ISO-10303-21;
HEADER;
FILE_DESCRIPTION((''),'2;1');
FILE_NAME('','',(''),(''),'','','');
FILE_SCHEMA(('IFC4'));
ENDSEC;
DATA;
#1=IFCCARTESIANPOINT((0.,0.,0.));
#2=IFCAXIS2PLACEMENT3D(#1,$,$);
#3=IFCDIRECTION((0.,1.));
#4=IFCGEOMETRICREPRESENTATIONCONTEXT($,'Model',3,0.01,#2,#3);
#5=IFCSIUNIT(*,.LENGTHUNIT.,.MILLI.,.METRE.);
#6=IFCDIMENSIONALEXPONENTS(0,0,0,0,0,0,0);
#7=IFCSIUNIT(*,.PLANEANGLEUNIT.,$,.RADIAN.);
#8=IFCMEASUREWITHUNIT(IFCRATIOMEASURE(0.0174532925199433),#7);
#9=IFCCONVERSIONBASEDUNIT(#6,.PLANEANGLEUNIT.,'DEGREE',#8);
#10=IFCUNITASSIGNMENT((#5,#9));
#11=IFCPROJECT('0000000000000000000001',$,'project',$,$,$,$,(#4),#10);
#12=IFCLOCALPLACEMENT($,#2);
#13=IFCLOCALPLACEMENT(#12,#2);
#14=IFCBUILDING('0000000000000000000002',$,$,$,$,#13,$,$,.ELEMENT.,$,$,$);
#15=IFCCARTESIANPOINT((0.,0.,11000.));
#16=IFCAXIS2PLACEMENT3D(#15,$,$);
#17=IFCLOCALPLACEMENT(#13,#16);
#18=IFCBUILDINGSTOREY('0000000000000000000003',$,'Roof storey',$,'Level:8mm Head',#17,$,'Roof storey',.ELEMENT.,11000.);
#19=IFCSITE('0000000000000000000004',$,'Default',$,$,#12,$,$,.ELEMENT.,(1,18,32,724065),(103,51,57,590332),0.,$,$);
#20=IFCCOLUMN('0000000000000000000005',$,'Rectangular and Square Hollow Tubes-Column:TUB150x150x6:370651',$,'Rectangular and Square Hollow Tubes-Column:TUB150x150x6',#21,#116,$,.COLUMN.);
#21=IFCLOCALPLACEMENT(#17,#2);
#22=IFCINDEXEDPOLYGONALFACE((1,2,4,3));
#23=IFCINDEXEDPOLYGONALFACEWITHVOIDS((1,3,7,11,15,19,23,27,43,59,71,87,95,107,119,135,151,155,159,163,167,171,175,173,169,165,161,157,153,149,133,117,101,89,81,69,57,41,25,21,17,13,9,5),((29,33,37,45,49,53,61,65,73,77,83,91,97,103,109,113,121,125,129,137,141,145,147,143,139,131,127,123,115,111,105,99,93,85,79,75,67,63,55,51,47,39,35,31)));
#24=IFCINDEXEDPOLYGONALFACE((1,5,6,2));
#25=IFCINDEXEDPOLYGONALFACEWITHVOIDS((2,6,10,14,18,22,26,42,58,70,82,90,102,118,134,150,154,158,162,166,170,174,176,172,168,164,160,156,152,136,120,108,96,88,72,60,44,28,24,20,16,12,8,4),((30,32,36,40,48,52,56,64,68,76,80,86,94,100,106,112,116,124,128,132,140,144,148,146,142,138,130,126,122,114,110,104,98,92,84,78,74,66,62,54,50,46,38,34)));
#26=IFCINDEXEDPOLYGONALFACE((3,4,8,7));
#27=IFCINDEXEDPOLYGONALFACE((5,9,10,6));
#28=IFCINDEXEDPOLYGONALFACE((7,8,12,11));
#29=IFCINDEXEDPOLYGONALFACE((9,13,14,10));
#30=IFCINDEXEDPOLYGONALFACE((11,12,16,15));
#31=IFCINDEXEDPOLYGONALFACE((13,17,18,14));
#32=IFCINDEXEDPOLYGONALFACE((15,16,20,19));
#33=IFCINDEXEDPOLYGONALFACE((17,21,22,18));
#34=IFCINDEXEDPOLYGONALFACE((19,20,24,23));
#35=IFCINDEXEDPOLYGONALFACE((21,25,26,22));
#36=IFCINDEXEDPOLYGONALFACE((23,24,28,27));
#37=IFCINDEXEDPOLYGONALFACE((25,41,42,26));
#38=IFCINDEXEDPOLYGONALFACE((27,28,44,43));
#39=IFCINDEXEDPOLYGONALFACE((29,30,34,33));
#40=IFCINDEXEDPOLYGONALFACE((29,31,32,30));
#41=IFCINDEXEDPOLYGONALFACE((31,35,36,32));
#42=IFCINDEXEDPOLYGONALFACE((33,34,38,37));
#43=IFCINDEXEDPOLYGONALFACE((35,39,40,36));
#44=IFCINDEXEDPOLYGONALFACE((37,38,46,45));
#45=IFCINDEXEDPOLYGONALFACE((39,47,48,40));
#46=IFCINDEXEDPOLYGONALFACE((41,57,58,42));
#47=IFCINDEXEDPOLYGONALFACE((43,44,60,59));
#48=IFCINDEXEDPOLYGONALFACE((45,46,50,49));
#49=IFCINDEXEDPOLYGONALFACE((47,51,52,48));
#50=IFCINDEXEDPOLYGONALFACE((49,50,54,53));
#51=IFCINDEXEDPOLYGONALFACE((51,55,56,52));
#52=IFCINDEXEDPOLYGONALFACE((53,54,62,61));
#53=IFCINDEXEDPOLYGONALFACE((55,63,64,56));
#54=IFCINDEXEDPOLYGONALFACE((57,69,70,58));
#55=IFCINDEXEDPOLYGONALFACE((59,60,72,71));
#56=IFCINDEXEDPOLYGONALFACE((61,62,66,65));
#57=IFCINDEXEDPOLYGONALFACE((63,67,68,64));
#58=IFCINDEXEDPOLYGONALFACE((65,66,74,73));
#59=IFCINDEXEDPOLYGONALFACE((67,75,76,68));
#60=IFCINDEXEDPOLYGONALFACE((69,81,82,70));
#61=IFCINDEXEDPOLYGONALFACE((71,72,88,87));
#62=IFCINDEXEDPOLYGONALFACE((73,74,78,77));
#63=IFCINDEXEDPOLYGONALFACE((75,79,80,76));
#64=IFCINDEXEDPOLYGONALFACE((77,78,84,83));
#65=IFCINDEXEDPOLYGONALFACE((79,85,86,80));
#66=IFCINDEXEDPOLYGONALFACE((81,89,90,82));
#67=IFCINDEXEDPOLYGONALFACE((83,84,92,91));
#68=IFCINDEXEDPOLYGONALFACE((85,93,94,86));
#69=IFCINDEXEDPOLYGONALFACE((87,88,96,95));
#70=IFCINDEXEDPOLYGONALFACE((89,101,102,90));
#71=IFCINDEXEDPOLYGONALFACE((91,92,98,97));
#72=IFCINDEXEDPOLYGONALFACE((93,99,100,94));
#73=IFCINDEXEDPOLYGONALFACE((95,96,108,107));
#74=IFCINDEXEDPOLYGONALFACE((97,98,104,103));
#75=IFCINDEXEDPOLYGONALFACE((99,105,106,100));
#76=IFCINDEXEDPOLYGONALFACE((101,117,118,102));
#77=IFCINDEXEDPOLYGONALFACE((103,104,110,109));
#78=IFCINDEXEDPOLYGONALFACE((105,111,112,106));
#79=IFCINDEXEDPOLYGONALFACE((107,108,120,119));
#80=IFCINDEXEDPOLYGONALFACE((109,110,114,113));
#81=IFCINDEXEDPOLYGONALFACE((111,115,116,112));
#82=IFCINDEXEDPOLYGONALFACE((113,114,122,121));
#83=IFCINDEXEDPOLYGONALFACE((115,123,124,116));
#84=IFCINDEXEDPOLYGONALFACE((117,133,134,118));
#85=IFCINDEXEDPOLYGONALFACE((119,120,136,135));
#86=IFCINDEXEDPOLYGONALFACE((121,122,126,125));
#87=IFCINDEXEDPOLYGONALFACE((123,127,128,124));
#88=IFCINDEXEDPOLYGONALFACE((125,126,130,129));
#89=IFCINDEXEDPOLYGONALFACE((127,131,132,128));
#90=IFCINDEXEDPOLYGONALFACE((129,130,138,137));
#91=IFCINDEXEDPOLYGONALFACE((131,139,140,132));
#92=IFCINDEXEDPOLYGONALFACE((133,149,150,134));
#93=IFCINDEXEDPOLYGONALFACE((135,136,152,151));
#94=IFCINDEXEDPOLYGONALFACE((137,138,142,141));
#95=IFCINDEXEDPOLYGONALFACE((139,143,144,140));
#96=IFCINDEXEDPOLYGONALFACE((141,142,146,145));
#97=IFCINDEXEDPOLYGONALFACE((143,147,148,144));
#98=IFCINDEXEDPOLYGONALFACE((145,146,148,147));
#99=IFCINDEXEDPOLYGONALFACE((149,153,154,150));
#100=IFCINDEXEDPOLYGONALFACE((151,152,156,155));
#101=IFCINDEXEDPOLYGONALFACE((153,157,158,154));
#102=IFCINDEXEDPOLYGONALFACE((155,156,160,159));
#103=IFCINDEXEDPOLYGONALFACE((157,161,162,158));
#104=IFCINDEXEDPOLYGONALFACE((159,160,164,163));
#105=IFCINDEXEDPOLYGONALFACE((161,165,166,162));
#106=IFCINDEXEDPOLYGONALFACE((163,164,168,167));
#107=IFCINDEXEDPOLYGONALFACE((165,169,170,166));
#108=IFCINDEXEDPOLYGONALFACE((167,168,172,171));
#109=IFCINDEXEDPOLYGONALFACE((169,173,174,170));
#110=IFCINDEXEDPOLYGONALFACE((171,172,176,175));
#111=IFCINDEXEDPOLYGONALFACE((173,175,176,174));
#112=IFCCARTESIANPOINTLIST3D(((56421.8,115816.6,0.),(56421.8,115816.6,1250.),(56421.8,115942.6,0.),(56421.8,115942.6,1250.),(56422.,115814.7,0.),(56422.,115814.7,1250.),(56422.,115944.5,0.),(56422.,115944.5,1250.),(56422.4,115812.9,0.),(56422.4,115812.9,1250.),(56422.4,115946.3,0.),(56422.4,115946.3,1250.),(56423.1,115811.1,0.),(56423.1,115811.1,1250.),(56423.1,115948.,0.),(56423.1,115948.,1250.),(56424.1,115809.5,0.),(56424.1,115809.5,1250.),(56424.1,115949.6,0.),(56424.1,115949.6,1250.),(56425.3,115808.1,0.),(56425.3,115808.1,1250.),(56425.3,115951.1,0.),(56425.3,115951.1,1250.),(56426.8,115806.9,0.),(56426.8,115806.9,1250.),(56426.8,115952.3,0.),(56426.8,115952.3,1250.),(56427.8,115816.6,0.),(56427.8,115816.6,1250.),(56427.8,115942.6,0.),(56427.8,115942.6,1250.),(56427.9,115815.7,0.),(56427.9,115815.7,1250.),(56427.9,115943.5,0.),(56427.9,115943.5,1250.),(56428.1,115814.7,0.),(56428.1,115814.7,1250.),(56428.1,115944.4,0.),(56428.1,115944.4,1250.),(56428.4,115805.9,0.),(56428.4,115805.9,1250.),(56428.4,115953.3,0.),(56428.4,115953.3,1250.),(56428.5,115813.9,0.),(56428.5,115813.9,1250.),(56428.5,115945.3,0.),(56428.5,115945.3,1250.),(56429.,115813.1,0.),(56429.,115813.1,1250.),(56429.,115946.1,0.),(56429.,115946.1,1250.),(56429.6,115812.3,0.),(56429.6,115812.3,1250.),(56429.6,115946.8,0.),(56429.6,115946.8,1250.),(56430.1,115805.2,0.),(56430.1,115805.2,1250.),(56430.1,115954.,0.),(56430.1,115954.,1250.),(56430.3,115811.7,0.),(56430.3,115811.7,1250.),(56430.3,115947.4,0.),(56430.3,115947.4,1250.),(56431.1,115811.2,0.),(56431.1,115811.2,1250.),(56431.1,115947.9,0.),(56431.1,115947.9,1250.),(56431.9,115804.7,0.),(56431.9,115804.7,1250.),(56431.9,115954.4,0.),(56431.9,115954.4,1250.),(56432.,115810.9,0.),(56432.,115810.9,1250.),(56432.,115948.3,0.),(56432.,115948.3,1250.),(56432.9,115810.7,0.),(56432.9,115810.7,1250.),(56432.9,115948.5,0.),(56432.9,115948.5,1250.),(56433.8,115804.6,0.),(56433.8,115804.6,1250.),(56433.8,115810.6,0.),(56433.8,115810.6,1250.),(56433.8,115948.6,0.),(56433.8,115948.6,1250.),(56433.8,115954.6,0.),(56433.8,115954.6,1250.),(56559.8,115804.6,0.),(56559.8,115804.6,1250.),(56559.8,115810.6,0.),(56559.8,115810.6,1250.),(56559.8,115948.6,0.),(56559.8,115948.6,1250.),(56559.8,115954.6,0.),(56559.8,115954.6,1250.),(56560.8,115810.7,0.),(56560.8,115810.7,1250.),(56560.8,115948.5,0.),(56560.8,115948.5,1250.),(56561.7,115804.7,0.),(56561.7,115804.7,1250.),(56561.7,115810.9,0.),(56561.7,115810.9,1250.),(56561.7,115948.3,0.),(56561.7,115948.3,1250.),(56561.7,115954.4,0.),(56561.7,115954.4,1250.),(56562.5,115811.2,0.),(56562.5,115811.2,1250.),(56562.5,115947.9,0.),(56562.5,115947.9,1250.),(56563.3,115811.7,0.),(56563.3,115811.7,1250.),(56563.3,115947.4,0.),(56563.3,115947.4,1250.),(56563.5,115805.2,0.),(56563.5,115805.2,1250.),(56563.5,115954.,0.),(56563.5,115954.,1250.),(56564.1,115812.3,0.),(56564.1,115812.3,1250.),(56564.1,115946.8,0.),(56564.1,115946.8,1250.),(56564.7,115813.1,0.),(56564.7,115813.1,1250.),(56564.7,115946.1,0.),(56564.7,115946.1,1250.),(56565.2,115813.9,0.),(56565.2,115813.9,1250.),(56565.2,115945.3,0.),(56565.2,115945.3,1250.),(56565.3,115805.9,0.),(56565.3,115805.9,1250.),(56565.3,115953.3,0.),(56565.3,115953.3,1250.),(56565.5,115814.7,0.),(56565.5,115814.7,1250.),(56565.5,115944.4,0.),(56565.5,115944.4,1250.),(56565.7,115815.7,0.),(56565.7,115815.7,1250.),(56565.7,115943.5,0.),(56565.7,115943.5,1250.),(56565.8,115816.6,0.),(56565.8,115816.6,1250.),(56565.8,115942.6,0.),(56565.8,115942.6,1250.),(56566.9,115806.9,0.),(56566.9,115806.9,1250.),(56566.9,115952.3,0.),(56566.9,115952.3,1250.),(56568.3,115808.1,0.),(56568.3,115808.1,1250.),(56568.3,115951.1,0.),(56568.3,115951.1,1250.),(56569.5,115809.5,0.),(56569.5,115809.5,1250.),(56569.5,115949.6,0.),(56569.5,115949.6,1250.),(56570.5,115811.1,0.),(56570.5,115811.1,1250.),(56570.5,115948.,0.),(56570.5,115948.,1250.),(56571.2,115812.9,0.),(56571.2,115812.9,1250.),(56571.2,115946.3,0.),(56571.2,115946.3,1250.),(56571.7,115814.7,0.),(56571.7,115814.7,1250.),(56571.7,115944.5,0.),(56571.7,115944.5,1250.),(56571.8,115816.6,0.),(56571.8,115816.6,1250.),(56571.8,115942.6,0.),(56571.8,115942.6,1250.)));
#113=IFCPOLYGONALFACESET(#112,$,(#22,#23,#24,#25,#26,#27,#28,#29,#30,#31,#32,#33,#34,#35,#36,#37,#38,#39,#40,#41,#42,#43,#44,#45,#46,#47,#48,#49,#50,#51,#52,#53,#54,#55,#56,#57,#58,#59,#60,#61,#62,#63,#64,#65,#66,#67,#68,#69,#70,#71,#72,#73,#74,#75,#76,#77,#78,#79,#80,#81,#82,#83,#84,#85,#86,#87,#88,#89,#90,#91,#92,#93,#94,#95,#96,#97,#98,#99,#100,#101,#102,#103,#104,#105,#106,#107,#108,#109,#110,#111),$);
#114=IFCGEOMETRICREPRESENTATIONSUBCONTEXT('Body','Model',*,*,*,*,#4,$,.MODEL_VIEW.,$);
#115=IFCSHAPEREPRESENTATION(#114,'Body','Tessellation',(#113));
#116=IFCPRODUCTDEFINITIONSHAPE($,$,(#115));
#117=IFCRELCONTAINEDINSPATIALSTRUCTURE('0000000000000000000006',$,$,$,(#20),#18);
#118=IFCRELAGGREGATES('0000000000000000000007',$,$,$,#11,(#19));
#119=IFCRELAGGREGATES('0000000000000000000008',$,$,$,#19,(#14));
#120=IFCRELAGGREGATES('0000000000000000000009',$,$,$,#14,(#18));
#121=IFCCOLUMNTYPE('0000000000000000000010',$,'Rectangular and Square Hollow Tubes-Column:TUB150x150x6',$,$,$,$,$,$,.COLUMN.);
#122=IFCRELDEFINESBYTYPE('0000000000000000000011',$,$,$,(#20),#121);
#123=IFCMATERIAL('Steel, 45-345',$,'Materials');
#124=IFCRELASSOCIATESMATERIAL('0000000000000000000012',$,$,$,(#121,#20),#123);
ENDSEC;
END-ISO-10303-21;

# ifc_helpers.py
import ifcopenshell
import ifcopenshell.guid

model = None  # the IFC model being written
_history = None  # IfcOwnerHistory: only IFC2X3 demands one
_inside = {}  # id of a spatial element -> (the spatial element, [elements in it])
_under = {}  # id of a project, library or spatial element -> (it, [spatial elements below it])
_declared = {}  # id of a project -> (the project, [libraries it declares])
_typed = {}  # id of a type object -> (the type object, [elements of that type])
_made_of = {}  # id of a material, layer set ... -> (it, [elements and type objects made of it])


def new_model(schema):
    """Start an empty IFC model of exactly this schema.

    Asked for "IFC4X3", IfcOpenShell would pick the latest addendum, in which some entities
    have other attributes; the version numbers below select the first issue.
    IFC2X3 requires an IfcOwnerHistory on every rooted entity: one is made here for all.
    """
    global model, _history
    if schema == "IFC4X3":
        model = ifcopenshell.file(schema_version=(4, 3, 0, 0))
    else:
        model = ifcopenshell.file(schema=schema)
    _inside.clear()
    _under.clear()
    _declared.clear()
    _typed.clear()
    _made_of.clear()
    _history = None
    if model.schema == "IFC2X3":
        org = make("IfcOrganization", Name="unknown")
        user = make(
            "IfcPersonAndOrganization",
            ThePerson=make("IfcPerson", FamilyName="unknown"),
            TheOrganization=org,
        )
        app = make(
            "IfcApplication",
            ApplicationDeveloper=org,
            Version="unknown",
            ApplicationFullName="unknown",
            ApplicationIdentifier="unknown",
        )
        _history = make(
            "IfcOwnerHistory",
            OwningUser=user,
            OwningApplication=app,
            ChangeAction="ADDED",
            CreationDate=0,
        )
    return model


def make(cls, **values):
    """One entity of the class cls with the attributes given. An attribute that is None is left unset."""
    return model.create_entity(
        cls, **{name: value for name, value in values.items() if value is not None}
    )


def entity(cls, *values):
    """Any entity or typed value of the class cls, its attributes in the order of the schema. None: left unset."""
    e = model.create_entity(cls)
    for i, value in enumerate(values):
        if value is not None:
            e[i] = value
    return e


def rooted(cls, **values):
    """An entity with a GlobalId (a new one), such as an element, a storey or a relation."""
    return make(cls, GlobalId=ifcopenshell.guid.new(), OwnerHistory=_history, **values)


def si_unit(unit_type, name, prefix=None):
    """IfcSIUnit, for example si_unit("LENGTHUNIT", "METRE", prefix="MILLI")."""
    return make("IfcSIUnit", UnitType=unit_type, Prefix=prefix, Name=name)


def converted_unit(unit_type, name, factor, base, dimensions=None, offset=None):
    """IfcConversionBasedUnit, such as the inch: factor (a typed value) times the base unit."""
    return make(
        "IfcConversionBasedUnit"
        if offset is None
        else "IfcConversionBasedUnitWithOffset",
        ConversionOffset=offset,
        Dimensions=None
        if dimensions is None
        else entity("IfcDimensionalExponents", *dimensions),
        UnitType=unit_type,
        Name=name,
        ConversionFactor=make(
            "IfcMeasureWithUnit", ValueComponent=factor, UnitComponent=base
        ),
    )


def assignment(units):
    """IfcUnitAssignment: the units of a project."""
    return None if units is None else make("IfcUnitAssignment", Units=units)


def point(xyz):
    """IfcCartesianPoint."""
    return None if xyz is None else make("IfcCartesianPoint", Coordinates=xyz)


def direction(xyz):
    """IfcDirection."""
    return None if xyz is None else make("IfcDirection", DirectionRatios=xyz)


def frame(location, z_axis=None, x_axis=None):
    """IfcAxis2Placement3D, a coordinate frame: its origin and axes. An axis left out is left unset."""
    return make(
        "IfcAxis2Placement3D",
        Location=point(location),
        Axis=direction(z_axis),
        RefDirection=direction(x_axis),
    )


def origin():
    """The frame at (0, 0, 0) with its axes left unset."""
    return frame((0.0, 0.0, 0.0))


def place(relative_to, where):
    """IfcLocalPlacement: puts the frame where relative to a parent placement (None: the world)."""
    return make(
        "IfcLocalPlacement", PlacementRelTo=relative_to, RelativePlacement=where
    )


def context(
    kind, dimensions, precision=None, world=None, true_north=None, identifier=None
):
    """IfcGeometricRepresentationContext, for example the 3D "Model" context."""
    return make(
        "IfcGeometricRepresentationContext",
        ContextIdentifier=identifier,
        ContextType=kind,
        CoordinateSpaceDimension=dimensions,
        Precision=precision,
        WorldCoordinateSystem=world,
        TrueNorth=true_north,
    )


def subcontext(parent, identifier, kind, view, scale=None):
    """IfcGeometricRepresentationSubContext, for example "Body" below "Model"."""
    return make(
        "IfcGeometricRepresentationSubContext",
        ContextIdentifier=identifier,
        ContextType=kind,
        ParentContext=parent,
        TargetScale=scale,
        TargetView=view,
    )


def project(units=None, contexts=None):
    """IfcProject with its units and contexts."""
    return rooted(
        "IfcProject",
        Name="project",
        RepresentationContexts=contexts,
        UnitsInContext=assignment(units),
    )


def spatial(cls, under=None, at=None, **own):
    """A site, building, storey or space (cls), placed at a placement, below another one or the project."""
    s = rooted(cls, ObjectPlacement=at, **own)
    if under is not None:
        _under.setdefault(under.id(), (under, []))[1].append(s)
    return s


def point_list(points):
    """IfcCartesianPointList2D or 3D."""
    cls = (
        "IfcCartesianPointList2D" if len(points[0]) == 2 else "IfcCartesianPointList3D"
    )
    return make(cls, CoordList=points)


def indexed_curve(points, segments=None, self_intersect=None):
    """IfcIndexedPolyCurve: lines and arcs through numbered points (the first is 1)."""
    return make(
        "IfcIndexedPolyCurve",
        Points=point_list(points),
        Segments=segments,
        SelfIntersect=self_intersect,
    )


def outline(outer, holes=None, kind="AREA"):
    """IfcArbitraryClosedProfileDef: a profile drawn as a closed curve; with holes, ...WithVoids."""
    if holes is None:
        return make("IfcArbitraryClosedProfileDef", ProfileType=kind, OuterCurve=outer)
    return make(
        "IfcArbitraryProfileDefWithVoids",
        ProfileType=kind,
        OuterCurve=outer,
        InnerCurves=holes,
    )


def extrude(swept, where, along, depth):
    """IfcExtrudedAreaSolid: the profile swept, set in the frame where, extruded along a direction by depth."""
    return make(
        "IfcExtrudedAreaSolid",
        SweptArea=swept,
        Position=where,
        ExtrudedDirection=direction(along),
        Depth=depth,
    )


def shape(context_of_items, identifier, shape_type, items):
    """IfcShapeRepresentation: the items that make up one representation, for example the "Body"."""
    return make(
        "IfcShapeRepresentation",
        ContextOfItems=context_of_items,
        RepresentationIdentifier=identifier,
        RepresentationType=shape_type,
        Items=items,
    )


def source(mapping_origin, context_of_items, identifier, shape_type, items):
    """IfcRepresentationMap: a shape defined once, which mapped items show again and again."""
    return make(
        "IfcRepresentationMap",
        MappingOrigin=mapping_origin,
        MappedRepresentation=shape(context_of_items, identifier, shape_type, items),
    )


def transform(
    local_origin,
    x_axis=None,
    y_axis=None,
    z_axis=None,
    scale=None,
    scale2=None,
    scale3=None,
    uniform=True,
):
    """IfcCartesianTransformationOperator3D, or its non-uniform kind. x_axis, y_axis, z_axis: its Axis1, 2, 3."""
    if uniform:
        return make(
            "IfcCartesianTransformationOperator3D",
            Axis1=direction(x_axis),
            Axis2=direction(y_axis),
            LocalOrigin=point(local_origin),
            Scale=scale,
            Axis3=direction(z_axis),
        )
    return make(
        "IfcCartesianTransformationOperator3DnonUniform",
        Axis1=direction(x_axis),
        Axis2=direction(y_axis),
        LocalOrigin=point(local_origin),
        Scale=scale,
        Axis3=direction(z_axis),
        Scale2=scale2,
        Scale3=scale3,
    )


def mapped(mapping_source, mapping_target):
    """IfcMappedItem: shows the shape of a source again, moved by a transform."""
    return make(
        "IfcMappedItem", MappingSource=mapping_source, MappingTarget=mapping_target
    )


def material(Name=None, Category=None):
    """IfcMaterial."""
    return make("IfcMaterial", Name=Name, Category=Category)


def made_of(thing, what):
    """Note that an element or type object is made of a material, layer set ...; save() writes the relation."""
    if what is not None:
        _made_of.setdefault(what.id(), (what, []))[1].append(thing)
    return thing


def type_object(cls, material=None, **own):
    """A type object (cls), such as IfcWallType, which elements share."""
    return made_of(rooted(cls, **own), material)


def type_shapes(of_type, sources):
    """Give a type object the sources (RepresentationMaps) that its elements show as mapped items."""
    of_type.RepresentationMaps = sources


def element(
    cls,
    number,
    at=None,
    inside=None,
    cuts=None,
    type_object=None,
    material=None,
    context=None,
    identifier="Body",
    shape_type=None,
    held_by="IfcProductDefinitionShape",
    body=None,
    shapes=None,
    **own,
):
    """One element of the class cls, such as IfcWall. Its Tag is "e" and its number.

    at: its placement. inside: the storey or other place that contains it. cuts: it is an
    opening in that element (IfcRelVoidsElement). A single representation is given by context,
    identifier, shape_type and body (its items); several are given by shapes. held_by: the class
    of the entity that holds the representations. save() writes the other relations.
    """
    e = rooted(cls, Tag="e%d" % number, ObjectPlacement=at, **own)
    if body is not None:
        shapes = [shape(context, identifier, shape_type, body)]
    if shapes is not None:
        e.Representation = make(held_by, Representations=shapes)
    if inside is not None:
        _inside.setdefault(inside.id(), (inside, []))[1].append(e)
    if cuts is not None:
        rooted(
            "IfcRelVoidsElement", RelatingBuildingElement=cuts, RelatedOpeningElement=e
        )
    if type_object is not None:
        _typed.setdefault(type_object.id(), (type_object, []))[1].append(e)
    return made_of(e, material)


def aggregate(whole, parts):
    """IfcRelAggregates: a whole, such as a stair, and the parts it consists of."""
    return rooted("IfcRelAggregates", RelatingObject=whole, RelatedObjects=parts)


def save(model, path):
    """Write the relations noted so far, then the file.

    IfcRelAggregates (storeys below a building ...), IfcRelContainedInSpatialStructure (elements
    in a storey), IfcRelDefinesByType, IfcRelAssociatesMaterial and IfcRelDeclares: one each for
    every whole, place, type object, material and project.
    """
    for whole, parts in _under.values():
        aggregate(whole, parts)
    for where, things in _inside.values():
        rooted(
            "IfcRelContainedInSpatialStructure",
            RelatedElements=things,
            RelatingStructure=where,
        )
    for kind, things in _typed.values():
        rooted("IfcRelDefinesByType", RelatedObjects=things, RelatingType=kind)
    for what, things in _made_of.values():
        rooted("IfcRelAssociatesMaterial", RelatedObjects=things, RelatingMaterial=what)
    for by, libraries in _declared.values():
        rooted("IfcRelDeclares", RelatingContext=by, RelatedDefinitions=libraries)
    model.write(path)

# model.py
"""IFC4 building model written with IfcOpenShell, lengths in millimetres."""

from ifc_helpers import new_model, entity, si_unit, converted_unit, direction, frame, origin, place, context, subcontext, project, spatial, indexed_curve, outline, extrude, source, transform, mapped, material, type_object, type_shapes, element, save


model = new_model("IFC4")

# Units and contexts
model_context = context("Model", 3, precision=0.01, world=origin(), true_north=direction((0.0, 1.0)))
body_context = subcontext(model_context, "Body", "Model", "MODEL_VIEW")
ifc_project = project(units=[si_unit("LENGTHUNIT", "METRE", prefix="MILLI"), converted_unit("PLANEANGLEUNIT", "DEGREE", entity("IfcRatioMeasure", 0.0174532925199433), si_unit("PLANEANGLEUNIT", "RADIAN"), dimensions=[0, 0, 0, 0, 0, 0, 0])], contexts=[model_context])

# Site, building, storey
site_placement = place(None, origin())
site = spatial("IfcSite", under=ifc_project, at=site_placement, Name="Default", CompositionType="ELEMENT", RefLatitude=(1, 18, 32, 724065), RefLongitude=(103, 51, 57, 590332), RefElevation=0.0)
building_placement = place(site_placement, origin())
building = spatial("IfcBuilding", under=site, at=building_placement, CompositionType="ELEMENT")
storey_placement = place(building_placement, frame((0.0, 0.0, 11000.0)))
storey = spatial("IfcBuildingStorey", under=building, at=storey_placement, Name="Roof storey", ObjectType="Level:8mm Head", LongName="Roof storey", CompositionType="ELEMENT", Elevation=11000.0)

# Column
ifc_material = material(Name="Steel, 45-345", Category="Materials")
column_type = type_object("IfcColumnType", Name="Rectangular and Square Hollow Tubes-Column:TUB150x150x6", PredefinedType="COLUMN", material=ifc_material)
shared_shape_1 = source(origin(), body_context, "Body", "SweptSolid", [
    extrude(outline(indexed_curve([(-63.0, -75.0), (63.0, -75.0), (64.9, -74.9), (66.7, -74.4), (68.4, -73.7), (70.1, -72.7), (71.5, -71.5), (72.7, -70.1), (73.7, -68.4), (74.4, -66.7), (74.9, -64.9), (75.0, -63.0), (75.0, 63.0), (74.9, 64.9), (74.4, 66.7), (73.7, 68.4), (72.7, 70.1), (71.5, 71.5), (70.1, 72.7), (68.4, 73.7), (66.7, 74.4), (64.9, 74.9), (63.0, 75.0), (-63.0, 75.0), (-64.9, 74.9), (-66.7, 74.4), (-68.4, 73.7), (-70.1, 72.7), (-71.5, 71.5), (-72.7, 70.1), (-73.7, 68.4), (-74.4, 66.7), (-74.9, 64.9), (-75.0, 63.0), (-75.0, -63.0), (-74.9, -64.9), (-74.4, -66.7), (-73.7, -68.4), (-72.7, -70.1), (-71.5, -71.5), (-70.1, -72.7), (-68.4, -73.7), (-66.7, -74.4), (-64.9, -74.9), (-63.0, -75.0)], self_intersect=False), holes=[indexed_curve([(-63.0, -69.0), (-63.9, -68.9), (-64.9, -68.7), (-65.7, -68.3), (-66.5, -67.9), (-67.2, -67.2), (-67.9, -66.5), (-68.3, -65.7), (-68.7, -64.9), (-68.9, -63.9), (-69.0, -63.0), (-69.0, 63.0), (-68.9, 63.9), (-68.7, 64.9), (-68.3, 65.7), (-67.9, 66.5), (-67.2, 67.2), (-66.5, 67.9), (-65.7, 68.3), (-64.9, 68.7), (-63.9, 68.9), (-63.0, 69.0), (63.0, 69.0), (63.9, 68.9), (64.9, 68.7), (65.7, 68.3), (66.5, 67.9), (67.2, 67.2), (67.9, 66.5), (68.3, 65.7), (68.7, 64.9), (68.9, 63.9), (69.0, 63.0), (69.0, -63.0), (68.9, -63.9), (68.7, -64.9), (68.3, -65.7), (67.9, -66.5), (67.2, -67.2), (66.5, -67.9), (65.7, -68.3), (64.9, -68.7), (63.9, -68.9), (63.0, -69.0), (-63.0, -69.0)], self_intersect=False)]), frame((0.0, 0.0, 11000.0), z_axis=(0.0, 0.0, 1.0), x_axis=(-1.0, 0.0, 0.0)), (0.0, 0.0, 1.0), 1250.0),
])
type_shapes(column_type, [shared_shape_1])
for number, where, name in (
    (1, (56496.8, 115879.6, -11000.0), "Rectangular and Square Hollow Tubes-Column:TUB150x150x6:370651"),
):
    element("IfcColumn", number, at=place(storey_placement, frame(where)), inside=storey, type_object=column_type, material=ifc_material, Name=name, ObjectType="Rectangular and Square Hollow Tubes-Column:TUB150x150x6", PredefinedType="COLUMN", context=body_context, shape_type="MappedRepresentation", body=[
        mapped(shared_shape_1, transform((0.0, 0.0, 0.0), scale=1.0)),
    ])

save(model, "model.ifc")
